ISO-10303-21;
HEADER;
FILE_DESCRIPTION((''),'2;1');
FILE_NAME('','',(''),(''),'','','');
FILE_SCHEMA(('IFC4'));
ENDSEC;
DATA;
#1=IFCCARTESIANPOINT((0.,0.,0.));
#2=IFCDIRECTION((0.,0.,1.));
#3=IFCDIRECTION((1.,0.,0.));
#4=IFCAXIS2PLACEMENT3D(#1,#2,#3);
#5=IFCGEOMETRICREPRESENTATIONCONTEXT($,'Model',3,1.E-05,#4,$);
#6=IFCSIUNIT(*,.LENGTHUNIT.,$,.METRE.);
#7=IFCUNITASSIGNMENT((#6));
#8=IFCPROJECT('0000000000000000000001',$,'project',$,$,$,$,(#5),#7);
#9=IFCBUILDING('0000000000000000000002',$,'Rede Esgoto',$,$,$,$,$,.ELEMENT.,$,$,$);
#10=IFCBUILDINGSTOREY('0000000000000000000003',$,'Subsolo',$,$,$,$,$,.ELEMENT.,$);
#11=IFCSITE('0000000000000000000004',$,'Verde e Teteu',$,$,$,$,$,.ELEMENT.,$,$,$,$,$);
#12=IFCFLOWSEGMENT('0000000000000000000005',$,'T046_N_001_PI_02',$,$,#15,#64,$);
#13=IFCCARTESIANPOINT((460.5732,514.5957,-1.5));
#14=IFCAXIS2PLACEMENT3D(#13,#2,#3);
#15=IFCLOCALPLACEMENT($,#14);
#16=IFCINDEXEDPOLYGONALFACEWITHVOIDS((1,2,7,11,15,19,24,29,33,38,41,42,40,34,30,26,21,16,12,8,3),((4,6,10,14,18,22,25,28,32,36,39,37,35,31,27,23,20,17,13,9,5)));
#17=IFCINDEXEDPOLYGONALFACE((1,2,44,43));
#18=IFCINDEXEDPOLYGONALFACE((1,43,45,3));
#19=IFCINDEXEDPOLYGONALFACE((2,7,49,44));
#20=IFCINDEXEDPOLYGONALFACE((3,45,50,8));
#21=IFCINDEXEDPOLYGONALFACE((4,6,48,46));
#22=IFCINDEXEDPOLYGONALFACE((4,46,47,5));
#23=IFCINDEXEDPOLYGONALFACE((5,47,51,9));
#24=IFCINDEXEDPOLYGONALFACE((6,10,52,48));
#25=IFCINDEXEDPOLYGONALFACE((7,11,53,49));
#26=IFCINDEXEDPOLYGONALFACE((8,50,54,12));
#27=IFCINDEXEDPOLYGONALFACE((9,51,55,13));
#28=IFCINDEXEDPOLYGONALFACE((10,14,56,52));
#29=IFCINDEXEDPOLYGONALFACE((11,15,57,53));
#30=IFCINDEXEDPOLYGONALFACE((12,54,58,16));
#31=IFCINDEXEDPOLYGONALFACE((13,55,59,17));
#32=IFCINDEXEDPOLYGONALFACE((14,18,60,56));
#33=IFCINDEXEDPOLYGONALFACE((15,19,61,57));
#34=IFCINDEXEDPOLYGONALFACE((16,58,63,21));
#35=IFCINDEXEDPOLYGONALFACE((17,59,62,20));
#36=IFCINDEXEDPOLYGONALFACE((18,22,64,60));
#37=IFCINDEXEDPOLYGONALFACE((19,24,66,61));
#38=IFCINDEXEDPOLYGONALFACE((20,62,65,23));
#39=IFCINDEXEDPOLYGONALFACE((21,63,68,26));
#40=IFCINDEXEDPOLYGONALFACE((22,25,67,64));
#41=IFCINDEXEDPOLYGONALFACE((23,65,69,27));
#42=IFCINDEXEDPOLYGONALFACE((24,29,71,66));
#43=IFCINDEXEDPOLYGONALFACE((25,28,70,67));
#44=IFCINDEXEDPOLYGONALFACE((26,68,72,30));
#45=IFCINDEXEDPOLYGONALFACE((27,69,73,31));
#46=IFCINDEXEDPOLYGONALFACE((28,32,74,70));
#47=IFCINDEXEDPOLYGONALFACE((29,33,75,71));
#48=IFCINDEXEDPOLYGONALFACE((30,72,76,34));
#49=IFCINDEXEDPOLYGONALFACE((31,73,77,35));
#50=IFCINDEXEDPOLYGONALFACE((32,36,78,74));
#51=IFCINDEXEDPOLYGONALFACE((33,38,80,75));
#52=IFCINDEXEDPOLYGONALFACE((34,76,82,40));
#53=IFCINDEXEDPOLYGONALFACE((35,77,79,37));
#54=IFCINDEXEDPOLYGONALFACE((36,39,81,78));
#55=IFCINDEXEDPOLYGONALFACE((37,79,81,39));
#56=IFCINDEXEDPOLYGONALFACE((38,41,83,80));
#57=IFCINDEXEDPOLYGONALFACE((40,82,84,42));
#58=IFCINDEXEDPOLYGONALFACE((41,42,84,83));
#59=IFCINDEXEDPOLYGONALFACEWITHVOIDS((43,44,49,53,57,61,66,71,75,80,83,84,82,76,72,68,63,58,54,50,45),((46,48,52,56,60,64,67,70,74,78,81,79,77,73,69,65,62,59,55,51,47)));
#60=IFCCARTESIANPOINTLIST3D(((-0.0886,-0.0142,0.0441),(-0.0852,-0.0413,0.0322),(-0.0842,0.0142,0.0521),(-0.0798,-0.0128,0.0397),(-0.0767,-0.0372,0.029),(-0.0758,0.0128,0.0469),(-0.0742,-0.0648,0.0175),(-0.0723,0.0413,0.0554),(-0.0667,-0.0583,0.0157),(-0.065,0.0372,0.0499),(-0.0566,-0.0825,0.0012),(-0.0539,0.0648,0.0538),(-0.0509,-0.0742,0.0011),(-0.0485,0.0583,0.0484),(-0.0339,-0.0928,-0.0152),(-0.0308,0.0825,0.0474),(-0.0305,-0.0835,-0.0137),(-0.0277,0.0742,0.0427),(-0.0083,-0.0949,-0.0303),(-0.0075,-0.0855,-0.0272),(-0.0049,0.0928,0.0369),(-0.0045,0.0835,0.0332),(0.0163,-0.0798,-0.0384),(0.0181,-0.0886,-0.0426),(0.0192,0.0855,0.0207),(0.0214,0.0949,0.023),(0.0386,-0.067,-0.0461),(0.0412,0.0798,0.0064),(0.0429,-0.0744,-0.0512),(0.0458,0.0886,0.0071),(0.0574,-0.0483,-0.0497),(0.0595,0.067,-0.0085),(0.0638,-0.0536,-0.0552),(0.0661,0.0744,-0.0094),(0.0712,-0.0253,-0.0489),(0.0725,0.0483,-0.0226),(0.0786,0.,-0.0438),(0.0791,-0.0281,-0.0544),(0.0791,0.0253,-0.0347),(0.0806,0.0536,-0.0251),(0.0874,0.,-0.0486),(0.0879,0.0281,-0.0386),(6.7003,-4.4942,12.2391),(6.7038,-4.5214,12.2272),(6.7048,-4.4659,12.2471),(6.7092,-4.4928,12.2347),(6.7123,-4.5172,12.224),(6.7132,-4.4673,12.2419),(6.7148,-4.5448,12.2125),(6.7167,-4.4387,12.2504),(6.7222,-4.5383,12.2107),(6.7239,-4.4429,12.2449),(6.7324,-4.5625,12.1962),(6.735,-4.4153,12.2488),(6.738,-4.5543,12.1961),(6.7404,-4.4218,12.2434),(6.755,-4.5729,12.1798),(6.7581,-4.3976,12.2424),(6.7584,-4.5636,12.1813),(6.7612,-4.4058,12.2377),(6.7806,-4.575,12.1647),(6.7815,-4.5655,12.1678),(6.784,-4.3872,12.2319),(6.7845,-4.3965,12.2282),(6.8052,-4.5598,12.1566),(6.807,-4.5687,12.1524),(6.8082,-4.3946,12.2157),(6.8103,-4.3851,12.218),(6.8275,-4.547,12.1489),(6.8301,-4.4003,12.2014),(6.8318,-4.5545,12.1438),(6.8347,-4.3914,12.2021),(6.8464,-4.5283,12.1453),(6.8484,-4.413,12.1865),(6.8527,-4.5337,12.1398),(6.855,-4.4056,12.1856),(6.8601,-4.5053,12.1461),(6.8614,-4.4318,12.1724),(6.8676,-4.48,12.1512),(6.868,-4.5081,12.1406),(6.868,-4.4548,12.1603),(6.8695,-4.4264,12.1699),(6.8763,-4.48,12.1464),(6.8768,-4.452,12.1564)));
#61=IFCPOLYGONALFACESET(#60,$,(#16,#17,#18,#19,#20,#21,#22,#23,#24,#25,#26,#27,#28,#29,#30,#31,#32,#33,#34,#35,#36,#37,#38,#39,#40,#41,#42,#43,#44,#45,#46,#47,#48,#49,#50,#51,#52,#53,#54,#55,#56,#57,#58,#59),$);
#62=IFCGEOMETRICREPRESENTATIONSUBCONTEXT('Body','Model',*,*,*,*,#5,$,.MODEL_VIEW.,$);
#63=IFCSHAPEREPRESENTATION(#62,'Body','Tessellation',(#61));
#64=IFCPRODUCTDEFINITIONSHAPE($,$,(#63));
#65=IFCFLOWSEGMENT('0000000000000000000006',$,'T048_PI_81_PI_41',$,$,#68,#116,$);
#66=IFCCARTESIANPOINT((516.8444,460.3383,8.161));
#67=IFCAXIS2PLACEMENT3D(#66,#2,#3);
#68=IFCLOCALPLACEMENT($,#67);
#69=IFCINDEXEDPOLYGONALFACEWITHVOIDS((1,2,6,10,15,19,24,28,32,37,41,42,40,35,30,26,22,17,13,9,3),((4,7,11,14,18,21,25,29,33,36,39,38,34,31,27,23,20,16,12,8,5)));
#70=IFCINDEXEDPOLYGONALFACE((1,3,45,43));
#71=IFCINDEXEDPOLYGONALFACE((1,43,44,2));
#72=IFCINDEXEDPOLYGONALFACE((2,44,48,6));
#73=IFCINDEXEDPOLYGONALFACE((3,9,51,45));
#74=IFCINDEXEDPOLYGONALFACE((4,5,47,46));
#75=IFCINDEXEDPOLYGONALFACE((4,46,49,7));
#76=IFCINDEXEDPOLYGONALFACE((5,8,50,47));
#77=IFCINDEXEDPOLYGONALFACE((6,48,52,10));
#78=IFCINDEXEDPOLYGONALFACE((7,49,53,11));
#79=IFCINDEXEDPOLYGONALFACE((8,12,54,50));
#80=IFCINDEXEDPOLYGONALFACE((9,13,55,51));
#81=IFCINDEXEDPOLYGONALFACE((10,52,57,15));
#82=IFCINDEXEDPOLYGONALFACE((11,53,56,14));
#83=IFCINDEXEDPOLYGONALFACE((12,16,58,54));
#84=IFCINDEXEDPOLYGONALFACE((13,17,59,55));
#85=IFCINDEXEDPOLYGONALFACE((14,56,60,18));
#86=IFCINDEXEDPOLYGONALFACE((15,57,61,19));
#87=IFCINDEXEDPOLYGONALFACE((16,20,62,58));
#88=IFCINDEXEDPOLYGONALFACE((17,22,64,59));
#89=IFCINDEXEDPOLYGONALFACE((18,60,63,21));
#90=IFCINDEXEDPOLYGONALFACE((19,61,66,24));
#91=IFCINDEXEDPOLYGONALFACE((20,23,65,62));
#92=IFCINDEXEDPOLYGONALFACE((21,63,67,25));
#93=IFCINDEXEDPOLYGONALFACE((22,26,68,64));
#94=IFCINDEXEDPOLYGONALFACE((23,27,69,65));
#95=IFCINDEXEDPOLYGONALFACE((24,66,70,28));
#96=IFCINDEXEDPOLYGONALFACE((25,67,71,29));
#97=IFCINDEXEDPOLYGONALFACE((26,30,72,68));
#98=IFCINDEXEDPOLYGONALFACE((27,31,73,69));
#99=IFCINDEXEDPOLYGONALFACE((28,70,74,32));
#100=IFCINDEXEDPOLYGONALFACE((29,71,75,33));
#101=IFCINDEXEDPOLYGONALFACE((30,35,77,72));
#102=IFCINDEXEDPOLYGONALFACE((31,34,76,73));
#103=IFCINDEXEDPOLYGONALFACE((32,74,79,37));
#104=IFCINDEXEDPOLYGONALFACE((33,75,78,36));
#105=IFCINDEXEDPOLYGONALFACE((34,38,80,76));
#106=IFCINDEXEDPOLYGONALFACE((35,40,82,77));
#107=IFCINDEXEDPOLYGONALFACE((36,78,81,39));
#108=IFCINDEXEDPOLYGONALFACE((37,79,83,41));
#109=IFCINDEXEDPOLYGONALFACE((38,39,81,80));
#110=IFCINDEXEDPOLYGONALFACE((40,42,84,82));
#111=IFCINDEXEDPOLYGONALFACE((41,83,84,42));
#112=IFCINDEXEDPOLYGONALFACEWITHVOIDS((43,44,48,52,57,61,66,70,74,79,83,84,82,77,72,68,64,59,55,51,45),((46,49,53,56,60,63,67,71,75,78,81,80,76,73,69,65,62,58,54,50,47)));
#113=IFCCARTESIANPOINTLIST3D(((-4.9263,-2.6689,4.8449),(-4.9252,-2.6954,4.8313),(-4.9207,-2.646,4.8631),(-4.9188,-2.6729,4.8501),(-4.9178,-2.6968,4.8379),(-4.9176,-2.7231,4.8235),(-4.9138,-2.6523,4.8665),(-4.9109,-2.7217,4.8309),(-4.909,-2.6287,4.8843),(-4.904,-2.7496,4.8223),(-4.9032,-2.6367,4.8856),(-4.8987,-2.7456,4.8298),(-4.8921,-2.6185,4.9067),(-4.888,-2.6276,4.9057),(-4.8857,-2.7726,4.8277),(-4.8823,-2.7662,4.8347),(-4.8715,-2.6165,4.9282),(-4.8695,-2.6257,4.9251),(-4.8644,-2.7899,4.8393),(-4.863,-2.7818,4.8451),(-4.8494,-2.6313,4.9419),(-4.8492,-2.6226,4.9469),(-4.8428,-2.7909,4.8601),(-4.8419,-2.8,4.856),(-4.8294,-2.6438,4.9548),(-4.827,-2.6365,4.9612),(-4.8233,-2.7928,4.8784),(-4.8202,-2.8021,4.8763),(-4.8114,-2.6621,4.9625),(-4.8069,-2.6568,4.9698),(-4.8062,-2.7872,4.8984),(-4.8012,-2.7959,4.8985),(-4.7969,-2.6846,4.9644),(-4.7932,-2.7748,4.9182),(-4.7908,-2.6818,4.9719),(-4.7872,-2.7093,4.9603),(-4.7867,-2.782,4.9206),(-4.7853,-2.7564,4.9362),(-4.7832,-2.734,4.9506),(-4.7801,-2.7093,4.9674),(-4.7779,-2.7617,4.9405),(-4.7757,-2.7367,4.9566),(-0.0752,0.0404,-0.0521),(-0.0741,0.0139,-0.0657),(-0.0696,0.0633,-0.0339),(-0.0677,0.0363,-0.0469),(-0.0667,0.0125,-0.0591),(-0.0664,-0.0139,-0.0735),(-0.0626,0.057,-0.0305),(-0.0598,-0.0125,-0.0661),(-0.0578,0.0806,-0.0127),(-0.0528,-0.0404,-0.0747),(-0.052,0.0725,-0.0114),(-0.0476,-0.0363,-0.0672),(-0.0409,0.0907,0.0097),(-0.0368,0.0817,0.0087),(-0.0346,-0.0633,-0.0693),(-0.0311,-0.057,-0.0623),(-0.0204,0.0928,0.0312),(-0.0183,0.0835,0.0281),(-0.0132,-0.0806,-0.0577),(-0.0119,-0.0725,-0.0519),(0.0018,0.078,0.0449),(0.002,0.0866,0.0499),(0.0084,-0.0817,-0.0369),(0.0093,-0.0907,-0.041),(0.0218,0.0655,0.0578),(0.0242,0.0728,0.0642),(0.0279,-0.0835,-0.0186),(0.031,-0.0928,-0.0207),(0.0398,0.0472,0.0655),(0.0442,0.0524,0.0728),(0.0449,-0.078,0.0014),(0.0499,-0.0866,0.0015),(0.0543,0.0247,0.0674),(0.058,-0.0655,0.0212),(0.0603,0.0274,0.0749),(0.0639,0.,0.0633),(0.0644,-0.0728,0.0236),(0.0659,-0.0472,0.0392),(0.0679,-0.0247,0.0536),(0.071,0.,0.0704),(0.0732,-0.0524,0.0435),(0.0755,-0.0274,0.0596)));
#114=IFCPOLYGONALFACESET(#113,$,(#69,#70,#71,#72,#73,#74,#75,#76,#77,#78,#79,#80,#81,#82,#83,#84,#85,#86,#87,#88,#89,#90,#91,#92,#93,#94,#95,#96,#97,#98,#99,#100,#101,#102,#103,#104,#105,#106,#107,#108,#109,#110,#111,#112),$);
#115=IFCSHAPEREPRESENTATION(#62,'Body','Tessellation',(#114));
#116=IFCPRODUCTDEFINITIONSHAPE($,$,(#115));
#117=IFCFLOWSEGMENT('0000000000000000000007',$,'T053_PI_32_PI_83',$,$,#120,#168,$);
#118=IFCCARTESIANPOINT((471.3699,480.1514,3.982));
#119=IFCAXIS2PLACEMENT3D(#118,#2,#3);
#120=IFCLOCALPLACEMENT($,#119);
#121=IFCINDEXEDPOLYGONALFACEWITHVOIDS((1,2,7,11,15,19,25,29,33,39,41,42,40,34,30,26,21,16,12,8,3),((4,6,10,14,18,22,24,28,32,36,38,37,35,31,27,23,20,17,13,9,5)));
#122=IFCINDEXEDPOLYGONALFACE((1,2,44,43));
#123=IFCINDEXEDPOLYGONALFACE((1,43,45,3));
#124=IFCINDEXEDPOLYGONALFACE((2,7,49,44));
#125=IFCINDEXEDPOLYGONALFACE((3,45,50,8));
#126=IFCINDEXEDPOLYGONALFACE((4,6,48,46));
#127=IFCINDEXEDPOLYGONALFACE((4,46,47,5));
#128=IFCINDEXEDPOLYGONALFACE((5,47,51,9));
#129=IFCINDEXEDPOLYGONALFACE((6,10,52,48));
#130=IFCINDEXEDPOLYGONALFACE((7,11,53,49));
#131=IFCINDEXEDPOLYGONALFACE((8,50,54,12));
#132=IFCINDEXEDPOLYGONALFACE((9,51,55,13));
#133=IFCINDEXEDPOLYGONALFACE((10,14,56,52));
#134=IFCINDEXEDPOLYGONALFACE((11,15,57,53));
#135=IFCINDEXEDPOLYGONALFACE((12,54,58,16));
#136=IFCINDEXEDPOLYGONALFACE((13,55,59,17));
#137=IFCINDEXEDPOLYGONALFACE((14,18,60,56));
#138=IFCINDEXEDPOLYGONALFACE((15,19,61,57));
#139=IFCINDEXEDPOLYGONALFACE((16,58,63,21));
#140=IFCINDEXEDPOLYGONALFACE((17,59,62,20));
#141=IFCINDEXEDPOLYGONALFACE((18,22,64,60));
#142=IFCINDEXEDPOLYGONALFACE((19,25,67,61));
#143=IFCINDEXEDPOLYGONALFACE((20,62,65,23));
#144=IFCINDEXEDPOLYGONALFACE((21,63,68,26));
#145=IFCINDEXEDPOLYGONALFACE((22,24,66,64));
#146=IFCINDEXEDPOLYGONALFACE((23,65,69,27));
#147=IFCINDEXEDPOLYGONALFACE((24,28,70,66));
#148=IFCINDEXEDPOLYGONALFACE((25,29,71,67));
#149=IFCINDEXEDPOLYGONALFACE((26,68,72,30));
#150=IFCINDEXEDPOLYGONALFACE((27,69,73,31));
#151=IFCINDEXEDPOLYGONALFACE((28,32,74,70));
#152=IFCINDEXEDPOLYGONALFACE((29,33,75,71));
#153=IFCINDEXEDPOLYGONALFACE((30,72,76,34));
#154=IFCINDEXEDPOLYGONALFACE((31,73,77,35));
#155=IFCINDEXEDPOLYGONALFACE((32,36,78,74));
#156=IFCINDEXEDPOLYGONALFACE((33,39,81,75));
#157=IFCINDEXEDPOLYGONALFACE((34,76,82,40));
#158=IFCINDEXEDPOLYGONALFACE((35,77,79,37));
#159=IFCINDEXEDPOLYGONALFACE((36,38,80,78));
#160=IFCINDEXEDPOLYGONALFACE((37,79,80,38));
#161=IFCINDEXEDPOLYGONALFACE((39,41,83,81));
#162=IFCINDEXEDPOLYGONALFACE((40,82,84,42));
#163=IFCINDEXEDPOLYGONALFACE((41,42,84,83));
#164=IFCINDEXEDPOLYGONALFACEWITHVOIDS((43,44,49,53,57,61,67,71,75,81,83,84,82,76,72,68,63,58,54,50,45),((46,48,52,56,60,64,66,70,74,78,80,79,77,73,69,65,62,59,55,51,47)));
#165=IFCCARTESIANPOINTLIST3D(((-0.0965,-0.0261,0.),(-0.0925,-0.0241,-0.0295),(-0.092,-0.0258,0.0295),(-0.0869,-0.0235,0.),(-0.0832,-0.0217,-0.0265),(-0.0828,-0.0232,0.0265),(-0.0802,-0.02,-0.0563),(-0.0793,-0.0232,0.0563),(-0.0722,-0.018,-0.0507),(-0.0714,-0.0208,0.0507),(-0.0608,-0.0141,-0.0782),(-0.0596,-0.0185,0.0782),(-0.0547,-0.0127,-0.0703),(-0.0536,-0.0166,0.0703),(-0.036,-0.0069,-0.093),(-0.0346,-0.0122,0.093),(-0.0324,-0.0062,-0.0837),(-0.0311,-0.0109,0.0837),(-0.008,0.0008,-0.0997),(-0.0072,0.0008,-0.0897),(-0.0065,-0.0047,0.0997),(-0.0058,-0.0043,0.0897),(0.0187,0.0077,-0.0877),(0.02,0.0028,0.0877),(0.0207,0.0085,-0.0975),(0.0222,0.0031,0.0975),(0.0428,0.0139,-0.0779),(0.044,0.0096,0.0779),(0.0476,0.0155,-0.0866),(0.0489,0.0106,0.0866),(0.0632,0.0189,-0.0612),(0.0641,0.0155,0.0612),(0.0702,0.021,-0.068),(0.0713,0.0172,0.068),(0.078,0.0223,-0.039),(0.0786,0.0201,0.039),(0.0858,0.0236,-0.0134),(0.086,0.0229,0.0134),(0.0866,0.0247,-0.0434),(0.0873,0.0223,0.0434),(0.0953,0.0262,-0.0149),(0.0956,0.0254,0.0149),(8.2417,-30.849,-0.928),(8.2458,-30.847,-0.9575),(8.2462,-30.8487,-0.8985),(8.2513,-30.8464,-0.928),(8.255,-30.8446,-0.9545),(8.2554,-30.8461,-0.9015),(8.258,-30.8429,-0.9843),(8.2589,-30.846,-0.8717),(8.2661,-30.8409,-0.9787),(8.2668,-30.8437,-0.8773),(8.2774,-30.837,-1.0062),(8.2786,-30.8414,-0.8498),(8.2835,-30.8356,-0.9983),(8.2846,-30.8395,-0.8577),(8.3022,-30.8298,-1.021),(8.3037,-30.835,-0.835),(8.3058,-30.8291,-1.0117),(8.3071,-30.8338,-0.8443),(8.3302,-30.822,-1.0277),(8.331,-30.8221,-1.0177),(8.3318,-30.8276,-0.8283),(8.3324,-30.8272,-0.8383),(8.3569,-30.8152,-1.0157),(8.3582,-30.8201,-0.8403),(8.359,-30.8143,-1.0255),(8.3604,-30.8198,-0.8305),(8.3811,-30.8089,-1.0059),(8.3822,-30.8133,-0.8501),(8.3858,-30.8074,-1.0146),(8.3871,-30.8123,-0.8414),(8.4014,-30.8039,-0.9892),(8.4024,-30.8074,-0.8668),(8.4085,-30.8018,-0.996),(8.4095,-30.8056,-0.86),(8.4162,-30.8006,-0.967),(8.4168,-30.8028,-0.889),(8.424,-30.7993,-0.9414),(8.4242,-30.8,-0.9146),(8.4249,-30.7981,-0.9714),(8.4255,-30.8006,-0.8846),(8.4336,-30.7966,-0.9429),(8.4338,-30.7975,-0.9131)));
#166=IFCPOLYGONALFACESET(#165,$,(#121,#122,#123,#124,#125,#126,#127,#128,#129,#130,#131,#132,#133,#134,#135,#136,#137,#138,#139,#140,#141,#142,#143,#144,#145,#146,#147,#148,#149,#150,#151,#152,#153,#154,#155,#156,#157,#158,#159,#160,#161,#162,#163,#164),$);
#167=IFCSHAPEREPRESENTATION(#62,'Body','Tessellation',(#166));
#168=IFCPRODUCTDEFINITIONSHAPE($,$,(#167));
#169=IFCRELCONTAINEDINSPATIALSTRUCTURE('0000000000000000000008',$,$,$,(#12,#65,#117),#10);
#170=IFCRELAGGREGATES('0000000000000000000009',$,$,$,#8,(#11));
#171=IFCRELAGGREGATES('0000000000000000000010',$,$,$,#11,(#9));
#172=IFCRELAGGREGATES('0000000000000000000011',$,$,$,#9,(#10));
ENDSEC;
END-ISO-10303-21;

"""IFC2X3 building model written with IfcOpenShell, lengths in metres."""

from ifc_helpers import new_model, entity, si_unit, frame, origin_with_axes, place, context, subcontext, project, spatial, element, save


model = new_model("IFC2X3")

# Units and contexts
model_context = context("Model", 3, precision=1e-05, world=origin_with_axes())
body_context = subcontext(model_context, "Body", "Model", "MODEL_VIEW")
ifc_project = project(units=[si_unit("LENGTHUNIT", "METRE")], contexts=[model_context])

# Site, building, storey
site = spatial("IfcSite", under=ifc_project, Name="Verde e Teteu", CompositionType="ELEMENT")
building = spatial("IfcBuilding", under=site, Name="Rede Esgoto", CompositionType="ELEMENT")
storey = spatial("IfcBuildingStorey", under=building, Name="Subsolo", CompositionType="ELEMENT")

# Flow segments
flow_segment_1_placement = place(None, frame((460.5732, 514.5957, -1.5), z_axis=(0.0, 0.0, 1.0), x_axis=(1.0, 0.0, 0.0)))
element("IfcFlowSegment", 1, at=flow_segment_1_placement, inside=storey, Name="T046_N_001_PI_02", context=body_context, shape_type="SweptSolid", body=[
    entity("IfcSweptDiskSolid", entity("IfcPolyline", [entity("IfcCartesianPoint", [0.0, 0.0, 0.0]), entity("IfcCartesianPoint", [6.7889, -4.48, 12.195])]), 0.1, 0.09),
])
flow_segment_2_placement = place(None, frame((516.8444, 460.3383, 8.161), z_axis=(0.0, 0.0, 1.0), x_axis=(1.0, 0.0, 0.0)))
element("IfcFlowSegment", 2, at=flow_segment_2_placement, inside=storey, Name="T048_PI_81_PI_41", context=body_context, shape_type="SweptSolid", body=[
    entity("IfcSweptDiskSolid", entity("IfcPolyline", [entity("IfcCartesianPoint", [0.0, 0.0, 0.0]), entity("IfcCartesianPoint", [-4.8511, -2.7093, 4.897])]), 0.1, 0.09),
])
flow_segment_3_placement = place(None, frame((471.3699, 480.1514, 3.982), z_axis=(0.0, 0.0, 1.0), x_axis=(1.0, 0.0, 0.0)))
element("IfcFlowSegment", 3, at=flow_segment_3_placement, inside=storey, Name="T053_PI_32_PI_83", context=body_context, shape_type="SweptSolid", body=[
    entity("IfcSweptDiskSolid", entity("IfcPolyline", [entity("IfcCartesianPoint", [0.0, 0.0, 0.0]), entity("IfcCartesianPoint", [8.3382, -30.8229, -0.928])]), 0.1, 0.09),
])

save(model, "model.ifc")
